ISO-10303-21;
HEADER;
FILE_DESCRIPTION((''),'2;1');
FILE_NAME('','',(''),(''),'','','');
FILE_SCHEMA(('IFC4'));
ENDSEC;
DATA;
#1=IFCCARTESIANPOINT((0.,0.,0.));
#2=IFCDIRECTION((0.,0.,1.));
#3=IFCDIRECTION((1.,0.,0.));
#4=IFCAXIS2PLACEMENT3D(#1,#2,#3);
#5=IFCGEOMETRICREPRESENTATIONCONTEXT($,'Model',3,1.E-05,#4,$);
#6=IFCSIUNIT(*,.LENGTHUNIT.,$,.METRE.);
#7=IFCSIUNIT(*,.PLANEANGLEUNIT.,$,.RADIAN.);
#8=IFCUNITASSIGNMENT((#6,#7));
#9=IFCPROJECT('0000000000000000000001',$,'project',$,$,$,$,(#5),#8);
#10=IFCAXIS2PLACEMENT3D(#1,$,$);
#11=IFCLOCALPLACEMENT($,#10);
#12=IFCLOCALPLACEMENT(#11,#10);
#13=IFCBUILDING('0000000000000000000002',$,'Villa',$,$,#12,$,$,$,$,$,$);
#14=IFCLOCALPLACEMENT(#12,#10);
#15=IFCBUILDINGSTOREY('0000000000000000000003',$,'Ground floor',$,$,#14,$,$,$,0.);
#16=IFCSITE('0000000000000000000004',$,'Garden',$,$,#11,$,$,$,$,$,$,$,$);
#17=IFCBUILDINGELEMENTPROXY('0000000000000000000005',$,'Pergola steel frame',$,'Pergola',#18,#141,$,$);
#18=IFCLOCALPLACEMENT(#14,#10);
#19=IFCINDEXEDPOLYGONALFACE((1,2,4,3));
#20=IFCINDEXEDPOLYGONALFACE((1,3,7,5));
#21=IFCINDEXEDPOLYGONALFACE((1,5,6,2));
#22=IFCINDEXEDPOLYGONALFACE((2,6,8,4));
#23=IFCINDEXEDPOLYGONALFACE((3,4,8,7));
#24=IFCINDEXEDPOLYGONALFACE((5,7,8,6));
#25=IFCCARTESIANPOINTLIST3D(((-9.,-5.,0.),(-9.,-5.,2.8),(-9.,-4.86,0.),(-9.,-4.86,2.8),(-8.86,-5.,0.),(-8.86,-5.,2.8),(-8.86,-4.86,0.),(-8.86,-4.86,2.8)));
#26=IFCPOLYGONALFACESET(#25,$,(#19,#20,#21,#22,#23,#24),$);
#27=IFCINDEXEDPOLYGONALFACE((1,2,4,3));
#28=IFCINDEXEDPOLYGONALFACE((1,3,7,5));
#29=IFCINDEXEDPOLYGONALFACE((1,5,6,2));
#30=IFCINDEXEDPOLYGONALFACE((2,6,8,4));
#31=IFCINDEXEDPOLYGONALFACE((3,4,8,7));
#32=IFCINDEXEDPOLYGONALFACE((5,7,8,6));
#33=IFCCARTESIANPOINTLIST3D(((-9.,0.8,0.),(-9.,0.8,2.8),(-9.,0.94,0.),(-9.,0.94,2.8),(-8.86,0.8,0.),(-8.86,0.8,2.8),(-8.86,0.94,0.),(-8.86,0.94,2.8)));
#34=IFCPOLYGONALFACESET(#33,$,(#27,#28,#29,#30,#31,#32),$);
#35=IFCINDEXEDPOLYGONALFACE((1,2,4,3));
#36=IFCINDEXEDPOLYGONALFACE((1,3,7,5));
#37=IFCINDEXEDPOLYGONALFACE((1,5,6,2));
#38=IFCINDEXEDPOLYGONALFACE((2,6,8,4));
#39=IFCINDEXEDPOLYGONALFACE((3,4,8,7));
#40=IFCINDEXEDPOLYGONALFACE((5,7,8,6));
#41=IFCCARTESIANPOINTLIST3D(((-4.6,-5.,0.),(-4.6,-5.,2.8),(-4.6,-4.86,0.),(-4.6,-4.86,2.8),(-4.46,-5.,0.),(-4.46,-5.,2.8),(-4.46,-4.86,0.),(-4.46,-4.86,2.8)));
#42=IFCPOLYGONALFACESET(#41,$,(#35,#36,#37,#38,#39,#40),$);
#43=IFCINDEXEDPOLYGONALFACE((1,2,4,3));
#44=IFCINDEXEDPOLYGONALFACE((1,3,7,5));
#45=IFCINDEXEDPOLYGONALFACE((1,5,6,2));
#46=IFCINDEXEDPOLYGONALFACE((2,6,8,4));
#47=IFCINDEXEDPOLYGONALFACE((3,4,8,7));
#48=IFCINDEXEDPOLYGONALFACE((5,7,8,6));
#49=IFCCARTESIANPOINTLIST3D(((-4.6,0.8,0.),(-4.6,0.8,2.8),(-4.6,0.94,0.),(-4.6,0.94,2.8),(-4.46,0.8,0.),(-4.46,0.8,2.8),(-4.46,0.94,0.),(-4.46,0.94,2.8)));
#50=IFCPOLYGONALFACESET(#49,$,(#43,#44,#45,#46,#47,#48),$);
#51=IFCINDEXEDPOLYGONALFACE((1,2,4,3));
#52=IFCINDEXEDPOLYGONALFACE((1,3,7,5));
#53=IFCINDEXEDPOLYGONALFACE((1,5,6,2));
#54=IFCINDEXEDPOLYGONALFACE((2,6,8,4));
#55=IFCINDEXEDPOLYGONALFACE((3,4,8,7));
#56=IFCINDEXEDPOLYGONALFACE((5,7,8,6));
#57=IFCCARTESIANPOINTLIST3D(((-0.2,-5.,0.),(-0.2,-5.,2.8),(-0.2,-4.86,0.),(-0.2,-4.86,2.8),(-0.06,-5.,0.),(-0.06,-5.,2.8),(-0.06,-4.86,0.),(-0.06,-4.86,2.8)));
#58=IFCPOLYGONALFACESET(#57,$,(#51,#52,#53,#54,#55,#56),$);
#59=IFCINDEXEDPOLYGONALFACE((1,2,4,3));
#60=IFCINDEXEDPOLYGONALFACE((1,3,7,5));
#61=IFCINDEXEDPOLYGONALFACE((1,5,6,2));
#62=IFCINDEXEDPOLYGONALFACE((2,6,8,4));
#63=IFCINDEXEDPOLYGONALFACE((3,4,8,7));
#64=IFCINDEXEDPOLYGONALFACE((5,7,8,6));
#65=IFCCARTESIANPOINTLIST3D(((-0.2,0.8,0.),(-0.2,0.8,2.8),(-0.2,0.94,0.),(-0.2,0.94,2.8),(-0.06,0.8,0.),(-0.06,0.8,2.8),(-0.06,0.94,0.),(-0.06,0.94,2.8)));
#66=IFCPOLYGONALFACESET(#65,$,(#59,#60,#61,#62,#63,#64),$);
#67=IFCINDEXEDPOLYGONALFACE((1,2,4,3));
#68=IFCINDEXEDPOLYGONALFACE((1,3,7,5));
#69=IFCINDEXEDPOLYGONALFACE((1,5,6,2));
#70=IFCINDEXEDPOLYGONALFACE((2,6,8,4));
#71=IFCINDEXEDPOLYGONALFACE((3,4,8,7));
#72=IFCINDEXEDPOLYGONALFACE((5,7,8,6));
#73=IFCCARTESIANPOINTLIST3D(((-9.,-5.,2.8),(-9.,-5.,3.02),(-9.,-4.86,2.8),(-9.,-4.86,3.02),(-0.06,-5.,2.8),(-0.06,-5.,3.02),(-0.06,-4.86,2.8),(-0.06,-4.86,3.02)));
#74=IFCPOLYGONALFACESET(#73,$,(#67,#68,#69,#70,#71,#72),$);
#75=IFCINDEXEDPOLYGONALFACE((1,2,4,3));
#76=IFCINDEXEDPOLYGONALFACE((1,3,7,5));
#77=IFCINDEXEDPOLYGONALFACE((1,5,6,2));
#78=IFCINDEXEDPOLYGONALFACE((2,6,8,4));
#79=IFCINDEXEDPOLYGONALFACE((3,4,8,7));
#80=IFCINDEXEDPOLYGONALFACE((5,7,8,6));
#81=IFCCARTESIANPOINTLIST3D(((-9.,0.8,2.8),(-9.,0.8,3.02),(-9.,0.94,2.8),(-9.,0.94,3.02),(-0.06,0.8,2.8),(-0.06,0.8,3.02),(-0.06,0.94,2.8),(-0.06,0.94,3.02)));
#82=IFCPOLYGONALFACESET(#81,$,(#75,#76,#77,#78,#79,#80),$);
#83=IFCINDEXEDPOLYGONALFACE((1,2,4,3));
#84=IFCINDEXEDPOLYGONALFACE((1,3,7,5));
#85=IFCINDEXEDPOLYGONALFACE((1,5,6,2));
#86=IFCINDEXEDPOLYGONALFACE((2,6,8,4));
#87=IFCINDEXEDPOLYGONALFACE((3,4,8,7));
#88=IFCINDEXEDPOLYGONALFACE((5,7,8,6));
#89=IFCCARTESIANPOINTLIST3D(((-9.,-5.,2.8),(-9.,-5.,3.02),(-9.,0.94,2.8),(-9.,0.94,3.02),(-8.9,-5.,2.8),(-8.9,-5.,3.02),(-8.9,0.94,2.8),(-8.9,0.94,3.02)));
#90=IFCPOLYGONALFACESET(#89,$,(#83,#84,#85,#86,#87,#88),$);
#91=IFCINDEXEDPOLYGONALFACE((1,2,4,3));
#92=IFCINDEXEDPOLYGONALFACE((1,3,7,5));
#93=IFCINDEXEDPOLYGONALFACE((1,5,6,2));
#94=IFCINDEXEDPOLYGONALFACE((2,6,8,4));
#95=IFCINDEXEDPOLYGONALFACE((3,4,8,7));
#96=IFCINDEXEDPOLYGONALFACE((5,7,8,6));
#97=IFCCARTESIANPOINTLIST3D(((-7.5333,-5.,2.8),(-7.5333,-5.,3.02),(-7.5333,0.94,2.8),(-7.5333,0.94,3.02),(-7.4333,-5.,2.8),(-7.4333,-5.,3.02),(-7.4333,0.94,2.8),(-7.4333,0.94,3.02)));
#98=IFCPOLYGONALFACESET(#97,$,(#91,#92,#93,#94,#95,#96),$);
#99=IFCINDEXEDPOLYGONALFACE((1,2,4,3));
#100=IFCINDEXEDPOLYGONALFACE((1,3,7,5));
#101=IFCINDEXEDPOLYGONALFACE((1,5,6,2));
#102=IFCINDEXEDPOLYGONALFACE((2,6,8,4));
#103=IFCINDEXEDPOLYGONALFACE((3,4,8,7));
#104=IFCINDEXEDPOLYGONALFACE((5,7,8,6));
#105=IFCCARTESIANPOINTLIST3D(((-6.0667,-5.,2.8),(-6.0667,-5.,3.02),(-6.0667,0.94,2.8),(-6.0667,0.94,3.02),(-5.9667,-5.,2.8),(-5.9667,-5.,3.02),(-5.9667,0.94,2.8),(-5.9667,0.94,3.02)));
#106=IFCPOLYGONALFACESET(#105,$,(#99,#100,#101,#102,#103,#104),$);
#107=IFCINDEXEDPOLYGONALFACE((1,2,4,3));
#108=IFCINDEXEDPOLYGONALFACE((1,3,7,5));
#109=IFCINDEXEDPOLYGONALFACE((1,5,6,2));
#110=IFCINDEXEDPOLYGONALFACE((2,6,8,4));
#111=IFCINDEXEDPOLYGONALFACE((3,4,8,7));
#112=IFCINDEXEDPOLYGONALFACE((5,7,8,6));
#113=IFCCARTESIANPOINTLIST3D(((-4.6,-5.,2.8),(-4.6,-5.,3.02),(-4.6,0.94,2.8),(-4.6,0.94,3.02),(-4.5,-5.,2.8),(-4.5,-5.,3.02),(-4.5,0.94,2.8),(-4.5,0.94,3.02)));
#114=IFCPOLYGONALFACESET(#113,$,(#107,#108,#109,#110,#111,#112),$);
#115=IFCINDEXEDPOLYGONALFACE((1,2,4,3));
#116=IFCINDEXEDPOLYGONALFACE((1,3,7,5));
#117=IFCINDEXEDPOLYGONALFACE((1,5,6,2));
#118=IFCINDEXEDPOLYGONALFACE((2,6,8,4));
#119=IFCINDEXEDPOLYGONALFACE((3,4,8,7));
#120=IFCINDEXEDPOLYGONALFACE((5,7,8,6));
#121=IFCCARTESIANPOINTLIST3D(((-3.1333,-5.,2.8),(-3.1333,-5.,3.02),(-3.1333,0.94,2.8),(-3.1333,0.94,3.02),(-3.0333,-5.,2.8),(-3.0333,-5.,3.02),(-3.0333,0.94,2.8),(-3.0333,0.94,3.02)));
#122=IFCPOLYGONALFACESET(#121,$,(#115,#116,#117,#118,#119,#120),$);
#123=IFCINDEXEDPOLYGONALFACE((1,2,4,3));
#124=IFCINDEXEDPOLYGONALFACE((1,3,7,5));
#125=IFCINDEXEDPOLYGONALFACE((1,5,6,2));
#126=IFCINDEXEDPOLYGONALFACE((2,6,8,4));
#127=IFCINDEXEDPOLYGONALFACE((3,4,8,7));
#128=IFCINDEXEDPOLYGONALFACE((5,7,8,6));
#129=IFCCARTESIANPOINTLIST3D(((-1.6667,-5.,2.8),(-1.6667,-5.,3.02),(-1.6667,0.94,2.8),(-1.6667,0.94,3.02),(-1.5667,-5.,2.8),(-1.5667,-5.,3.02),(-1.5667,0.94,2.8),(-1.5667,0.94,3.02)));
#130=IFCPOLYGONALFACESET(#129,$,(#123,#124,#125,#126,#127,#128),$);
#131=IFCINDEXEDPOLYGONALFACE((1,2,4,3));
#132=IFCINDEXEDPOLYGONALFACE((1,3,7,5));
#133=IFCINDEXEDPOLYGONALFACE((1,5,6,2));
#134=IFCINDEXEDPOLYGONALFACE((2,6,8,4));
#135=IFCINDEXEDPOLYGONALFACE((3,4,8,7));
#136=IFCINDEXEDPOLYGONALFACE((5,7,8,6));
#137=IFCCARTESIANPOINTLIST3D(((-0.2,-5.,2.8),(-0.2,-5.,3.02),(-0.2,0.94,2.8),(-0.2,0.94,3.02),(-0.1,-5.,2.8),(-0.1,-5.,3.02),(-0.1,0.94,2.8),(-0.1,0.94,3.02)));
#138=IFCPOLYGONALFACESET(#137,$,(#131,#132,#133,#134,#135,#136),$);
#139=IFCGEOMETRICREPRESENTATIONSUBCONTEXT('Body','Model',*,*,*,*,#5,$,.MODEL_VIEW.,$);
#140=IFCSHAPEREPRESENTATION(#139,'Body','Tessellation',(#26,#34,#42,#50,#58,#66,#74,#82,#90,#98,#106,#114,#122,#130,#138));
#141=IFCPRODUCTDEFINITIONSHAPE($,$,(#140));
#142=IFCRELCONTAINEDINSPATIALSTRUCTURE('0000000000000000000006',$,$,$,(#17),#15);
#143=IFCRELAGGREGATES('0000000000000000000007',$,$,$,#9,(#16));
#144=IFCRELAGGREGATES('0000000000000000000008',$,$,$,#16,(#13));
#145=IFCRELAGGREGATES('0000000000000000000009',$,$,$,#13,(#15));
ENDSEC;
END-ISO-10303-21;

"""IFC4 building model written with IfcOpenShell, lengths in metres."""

from ifc_helpers import new_model, si_unit, frame, frame_2d, origin, origin_with_axes, place, context, subcontext, project, spatial, rectangle, extrude, element, save


model = new_model("IFC4")

# Units and contexts
model_context = context("Model", 3, precision=1e-05, world=origin_with_axes())
body_context = subcontext(model_context, "Body", "Model", "MODEL_VIEW")
ifc_project = project(units=[si_unit("LENGTHUNIT", "METRE"), si_unit("PLANEANGLEUNIT", "RADIAN")], contexts=[model_context])

# Site, building, storey
site_placement = place(None, origin())
site = spatial("IfcSite", under=ifc_project, at=site_placement, Name="Garden")
building_placement = place(site_placement, origin())
building = spatial("IfcBuilding", under=site, at=building_placement, Name="Villa")
storey_placement = place(building_placement, origin())
storey = spatial("IfcBuildingStorey", under=building, at=storey_placement, Name="Ground floor", Elevation=0.0)

# Building element proxy
proxy_placement = place(storey_placement, origin())
element("IfcBuildingElementProxy", 1, at=proxy_placement, inside=storey, Name="Pergola steel frame", ObjectType="Pergola", context=body_context, shape_type="SweptSolid", body=[
    extrude(rectangle(XDim=0.14, YDim=0.14, at=frame_2d((0.07, 0.07))), frame((-9.0, -5.0, 0.0)), (0.0, 0.0, 1.0), 2.8),
    extrude(rectangle(XDim=0.14, YDim=0.14, at=frame_2d((0.07, 0.07))), frame((-9.0, 0.8, 0.0)), (0.0, 0.0, 1.0), 2.8),
    extrude(rectangle(XDim=0.14, YDim=0.14, at=frame_2d((0.07, 0.07))), frame((-4.6, -5.0, 0.0)), (0.0, 0.0, 1.0), 2.8),
    extrude(rectangle(XDim=0.14, YDim=0.14, at=frame_2d((0.07, 0.07))), frame((-4.6, 0.8, 0.0)), (0.0, 0.0, 1.0), 2.8),
    extrude(rectangle(XDim=0.14, YDim=0.14, at=frame_2d((0.07, 0.07))), frame((-0.2, -5.0, 0.0)), (0.0, 0.0, 1.0), 2.8),
    extrude(rectangle(XDim=0.14, YDim=0.14, at=frame_2d((0.07, 0.07))), frame((-0.2, 0.8, 0.0)), (0.0, 0.0, 1.0), 2.8),
    extrude(rectangle(XDim=8.94, YDim=0.14, at=frame_2d((4.47, 0.07))), frame((-9.0, -5.0, 2.8)), (0.0, 0.0, 1.0), 0.22),
    extrude(rectangle(XDim=8.94, YDim=0.14, at=frame_2d((4.47, 0.07))), frame((-9.0, 0.8, 2.8)), (0.0, 0.0, 1.0), 0.22),
    extrude(rectangle(XDim=0.1, YDim=5.94, at=frame_2d((0.05, 2.97))), frame((-9.0, -5.0, 2.8)), (0.0, 0.0, 1.0), 0.22),
    extrude(rectangle(XDim=0.1, YDim=5.94, at=frame_2d((0.05, 2.97))), frame((-7.5333, -5.0, 2.8)), (0.0, 0.0, 1.0), 0.22),
    extrude(rectangle(XDim=0.1, YDim=5.94, at=frame_2d((0.05, 2.97))), frame((-6.0667, -5.0, 2.8)), (0.0, 0.0, 1.0), 0.22),
    extrude(rectangle(XDim=0.1, YDim=5.94, at=frame_2d((0.05, 2.97))), frame((-4.6, -5.0, 2.8)), (0.0, 0.0, 1.0), 0.22),
    extrude(rectangle(XDim=0.1, YDim=5.94, at=frame_2d((0.05, 2.97))), frame((-3.1333, -5.0, 2.8)), (0.0, 0.0, 1.0), 0.22),
    extrude(rectangle(XDim=0.1, YDim=5.94, at=frame_2d((0.05, 2.97))), frame((-1.6667, -5.0, 2.8)), (0.0, 0.0, 1.0), 0.22),
    extrude(rectangle(XDim=0.1, YDim=5.94, at=frame_2d((0.05, 2.97))), frame((-0.2, -5.0, 2.8)), (0.0, 0.0, 1.0), 0.22),
])

save(model, "model.ifc")
